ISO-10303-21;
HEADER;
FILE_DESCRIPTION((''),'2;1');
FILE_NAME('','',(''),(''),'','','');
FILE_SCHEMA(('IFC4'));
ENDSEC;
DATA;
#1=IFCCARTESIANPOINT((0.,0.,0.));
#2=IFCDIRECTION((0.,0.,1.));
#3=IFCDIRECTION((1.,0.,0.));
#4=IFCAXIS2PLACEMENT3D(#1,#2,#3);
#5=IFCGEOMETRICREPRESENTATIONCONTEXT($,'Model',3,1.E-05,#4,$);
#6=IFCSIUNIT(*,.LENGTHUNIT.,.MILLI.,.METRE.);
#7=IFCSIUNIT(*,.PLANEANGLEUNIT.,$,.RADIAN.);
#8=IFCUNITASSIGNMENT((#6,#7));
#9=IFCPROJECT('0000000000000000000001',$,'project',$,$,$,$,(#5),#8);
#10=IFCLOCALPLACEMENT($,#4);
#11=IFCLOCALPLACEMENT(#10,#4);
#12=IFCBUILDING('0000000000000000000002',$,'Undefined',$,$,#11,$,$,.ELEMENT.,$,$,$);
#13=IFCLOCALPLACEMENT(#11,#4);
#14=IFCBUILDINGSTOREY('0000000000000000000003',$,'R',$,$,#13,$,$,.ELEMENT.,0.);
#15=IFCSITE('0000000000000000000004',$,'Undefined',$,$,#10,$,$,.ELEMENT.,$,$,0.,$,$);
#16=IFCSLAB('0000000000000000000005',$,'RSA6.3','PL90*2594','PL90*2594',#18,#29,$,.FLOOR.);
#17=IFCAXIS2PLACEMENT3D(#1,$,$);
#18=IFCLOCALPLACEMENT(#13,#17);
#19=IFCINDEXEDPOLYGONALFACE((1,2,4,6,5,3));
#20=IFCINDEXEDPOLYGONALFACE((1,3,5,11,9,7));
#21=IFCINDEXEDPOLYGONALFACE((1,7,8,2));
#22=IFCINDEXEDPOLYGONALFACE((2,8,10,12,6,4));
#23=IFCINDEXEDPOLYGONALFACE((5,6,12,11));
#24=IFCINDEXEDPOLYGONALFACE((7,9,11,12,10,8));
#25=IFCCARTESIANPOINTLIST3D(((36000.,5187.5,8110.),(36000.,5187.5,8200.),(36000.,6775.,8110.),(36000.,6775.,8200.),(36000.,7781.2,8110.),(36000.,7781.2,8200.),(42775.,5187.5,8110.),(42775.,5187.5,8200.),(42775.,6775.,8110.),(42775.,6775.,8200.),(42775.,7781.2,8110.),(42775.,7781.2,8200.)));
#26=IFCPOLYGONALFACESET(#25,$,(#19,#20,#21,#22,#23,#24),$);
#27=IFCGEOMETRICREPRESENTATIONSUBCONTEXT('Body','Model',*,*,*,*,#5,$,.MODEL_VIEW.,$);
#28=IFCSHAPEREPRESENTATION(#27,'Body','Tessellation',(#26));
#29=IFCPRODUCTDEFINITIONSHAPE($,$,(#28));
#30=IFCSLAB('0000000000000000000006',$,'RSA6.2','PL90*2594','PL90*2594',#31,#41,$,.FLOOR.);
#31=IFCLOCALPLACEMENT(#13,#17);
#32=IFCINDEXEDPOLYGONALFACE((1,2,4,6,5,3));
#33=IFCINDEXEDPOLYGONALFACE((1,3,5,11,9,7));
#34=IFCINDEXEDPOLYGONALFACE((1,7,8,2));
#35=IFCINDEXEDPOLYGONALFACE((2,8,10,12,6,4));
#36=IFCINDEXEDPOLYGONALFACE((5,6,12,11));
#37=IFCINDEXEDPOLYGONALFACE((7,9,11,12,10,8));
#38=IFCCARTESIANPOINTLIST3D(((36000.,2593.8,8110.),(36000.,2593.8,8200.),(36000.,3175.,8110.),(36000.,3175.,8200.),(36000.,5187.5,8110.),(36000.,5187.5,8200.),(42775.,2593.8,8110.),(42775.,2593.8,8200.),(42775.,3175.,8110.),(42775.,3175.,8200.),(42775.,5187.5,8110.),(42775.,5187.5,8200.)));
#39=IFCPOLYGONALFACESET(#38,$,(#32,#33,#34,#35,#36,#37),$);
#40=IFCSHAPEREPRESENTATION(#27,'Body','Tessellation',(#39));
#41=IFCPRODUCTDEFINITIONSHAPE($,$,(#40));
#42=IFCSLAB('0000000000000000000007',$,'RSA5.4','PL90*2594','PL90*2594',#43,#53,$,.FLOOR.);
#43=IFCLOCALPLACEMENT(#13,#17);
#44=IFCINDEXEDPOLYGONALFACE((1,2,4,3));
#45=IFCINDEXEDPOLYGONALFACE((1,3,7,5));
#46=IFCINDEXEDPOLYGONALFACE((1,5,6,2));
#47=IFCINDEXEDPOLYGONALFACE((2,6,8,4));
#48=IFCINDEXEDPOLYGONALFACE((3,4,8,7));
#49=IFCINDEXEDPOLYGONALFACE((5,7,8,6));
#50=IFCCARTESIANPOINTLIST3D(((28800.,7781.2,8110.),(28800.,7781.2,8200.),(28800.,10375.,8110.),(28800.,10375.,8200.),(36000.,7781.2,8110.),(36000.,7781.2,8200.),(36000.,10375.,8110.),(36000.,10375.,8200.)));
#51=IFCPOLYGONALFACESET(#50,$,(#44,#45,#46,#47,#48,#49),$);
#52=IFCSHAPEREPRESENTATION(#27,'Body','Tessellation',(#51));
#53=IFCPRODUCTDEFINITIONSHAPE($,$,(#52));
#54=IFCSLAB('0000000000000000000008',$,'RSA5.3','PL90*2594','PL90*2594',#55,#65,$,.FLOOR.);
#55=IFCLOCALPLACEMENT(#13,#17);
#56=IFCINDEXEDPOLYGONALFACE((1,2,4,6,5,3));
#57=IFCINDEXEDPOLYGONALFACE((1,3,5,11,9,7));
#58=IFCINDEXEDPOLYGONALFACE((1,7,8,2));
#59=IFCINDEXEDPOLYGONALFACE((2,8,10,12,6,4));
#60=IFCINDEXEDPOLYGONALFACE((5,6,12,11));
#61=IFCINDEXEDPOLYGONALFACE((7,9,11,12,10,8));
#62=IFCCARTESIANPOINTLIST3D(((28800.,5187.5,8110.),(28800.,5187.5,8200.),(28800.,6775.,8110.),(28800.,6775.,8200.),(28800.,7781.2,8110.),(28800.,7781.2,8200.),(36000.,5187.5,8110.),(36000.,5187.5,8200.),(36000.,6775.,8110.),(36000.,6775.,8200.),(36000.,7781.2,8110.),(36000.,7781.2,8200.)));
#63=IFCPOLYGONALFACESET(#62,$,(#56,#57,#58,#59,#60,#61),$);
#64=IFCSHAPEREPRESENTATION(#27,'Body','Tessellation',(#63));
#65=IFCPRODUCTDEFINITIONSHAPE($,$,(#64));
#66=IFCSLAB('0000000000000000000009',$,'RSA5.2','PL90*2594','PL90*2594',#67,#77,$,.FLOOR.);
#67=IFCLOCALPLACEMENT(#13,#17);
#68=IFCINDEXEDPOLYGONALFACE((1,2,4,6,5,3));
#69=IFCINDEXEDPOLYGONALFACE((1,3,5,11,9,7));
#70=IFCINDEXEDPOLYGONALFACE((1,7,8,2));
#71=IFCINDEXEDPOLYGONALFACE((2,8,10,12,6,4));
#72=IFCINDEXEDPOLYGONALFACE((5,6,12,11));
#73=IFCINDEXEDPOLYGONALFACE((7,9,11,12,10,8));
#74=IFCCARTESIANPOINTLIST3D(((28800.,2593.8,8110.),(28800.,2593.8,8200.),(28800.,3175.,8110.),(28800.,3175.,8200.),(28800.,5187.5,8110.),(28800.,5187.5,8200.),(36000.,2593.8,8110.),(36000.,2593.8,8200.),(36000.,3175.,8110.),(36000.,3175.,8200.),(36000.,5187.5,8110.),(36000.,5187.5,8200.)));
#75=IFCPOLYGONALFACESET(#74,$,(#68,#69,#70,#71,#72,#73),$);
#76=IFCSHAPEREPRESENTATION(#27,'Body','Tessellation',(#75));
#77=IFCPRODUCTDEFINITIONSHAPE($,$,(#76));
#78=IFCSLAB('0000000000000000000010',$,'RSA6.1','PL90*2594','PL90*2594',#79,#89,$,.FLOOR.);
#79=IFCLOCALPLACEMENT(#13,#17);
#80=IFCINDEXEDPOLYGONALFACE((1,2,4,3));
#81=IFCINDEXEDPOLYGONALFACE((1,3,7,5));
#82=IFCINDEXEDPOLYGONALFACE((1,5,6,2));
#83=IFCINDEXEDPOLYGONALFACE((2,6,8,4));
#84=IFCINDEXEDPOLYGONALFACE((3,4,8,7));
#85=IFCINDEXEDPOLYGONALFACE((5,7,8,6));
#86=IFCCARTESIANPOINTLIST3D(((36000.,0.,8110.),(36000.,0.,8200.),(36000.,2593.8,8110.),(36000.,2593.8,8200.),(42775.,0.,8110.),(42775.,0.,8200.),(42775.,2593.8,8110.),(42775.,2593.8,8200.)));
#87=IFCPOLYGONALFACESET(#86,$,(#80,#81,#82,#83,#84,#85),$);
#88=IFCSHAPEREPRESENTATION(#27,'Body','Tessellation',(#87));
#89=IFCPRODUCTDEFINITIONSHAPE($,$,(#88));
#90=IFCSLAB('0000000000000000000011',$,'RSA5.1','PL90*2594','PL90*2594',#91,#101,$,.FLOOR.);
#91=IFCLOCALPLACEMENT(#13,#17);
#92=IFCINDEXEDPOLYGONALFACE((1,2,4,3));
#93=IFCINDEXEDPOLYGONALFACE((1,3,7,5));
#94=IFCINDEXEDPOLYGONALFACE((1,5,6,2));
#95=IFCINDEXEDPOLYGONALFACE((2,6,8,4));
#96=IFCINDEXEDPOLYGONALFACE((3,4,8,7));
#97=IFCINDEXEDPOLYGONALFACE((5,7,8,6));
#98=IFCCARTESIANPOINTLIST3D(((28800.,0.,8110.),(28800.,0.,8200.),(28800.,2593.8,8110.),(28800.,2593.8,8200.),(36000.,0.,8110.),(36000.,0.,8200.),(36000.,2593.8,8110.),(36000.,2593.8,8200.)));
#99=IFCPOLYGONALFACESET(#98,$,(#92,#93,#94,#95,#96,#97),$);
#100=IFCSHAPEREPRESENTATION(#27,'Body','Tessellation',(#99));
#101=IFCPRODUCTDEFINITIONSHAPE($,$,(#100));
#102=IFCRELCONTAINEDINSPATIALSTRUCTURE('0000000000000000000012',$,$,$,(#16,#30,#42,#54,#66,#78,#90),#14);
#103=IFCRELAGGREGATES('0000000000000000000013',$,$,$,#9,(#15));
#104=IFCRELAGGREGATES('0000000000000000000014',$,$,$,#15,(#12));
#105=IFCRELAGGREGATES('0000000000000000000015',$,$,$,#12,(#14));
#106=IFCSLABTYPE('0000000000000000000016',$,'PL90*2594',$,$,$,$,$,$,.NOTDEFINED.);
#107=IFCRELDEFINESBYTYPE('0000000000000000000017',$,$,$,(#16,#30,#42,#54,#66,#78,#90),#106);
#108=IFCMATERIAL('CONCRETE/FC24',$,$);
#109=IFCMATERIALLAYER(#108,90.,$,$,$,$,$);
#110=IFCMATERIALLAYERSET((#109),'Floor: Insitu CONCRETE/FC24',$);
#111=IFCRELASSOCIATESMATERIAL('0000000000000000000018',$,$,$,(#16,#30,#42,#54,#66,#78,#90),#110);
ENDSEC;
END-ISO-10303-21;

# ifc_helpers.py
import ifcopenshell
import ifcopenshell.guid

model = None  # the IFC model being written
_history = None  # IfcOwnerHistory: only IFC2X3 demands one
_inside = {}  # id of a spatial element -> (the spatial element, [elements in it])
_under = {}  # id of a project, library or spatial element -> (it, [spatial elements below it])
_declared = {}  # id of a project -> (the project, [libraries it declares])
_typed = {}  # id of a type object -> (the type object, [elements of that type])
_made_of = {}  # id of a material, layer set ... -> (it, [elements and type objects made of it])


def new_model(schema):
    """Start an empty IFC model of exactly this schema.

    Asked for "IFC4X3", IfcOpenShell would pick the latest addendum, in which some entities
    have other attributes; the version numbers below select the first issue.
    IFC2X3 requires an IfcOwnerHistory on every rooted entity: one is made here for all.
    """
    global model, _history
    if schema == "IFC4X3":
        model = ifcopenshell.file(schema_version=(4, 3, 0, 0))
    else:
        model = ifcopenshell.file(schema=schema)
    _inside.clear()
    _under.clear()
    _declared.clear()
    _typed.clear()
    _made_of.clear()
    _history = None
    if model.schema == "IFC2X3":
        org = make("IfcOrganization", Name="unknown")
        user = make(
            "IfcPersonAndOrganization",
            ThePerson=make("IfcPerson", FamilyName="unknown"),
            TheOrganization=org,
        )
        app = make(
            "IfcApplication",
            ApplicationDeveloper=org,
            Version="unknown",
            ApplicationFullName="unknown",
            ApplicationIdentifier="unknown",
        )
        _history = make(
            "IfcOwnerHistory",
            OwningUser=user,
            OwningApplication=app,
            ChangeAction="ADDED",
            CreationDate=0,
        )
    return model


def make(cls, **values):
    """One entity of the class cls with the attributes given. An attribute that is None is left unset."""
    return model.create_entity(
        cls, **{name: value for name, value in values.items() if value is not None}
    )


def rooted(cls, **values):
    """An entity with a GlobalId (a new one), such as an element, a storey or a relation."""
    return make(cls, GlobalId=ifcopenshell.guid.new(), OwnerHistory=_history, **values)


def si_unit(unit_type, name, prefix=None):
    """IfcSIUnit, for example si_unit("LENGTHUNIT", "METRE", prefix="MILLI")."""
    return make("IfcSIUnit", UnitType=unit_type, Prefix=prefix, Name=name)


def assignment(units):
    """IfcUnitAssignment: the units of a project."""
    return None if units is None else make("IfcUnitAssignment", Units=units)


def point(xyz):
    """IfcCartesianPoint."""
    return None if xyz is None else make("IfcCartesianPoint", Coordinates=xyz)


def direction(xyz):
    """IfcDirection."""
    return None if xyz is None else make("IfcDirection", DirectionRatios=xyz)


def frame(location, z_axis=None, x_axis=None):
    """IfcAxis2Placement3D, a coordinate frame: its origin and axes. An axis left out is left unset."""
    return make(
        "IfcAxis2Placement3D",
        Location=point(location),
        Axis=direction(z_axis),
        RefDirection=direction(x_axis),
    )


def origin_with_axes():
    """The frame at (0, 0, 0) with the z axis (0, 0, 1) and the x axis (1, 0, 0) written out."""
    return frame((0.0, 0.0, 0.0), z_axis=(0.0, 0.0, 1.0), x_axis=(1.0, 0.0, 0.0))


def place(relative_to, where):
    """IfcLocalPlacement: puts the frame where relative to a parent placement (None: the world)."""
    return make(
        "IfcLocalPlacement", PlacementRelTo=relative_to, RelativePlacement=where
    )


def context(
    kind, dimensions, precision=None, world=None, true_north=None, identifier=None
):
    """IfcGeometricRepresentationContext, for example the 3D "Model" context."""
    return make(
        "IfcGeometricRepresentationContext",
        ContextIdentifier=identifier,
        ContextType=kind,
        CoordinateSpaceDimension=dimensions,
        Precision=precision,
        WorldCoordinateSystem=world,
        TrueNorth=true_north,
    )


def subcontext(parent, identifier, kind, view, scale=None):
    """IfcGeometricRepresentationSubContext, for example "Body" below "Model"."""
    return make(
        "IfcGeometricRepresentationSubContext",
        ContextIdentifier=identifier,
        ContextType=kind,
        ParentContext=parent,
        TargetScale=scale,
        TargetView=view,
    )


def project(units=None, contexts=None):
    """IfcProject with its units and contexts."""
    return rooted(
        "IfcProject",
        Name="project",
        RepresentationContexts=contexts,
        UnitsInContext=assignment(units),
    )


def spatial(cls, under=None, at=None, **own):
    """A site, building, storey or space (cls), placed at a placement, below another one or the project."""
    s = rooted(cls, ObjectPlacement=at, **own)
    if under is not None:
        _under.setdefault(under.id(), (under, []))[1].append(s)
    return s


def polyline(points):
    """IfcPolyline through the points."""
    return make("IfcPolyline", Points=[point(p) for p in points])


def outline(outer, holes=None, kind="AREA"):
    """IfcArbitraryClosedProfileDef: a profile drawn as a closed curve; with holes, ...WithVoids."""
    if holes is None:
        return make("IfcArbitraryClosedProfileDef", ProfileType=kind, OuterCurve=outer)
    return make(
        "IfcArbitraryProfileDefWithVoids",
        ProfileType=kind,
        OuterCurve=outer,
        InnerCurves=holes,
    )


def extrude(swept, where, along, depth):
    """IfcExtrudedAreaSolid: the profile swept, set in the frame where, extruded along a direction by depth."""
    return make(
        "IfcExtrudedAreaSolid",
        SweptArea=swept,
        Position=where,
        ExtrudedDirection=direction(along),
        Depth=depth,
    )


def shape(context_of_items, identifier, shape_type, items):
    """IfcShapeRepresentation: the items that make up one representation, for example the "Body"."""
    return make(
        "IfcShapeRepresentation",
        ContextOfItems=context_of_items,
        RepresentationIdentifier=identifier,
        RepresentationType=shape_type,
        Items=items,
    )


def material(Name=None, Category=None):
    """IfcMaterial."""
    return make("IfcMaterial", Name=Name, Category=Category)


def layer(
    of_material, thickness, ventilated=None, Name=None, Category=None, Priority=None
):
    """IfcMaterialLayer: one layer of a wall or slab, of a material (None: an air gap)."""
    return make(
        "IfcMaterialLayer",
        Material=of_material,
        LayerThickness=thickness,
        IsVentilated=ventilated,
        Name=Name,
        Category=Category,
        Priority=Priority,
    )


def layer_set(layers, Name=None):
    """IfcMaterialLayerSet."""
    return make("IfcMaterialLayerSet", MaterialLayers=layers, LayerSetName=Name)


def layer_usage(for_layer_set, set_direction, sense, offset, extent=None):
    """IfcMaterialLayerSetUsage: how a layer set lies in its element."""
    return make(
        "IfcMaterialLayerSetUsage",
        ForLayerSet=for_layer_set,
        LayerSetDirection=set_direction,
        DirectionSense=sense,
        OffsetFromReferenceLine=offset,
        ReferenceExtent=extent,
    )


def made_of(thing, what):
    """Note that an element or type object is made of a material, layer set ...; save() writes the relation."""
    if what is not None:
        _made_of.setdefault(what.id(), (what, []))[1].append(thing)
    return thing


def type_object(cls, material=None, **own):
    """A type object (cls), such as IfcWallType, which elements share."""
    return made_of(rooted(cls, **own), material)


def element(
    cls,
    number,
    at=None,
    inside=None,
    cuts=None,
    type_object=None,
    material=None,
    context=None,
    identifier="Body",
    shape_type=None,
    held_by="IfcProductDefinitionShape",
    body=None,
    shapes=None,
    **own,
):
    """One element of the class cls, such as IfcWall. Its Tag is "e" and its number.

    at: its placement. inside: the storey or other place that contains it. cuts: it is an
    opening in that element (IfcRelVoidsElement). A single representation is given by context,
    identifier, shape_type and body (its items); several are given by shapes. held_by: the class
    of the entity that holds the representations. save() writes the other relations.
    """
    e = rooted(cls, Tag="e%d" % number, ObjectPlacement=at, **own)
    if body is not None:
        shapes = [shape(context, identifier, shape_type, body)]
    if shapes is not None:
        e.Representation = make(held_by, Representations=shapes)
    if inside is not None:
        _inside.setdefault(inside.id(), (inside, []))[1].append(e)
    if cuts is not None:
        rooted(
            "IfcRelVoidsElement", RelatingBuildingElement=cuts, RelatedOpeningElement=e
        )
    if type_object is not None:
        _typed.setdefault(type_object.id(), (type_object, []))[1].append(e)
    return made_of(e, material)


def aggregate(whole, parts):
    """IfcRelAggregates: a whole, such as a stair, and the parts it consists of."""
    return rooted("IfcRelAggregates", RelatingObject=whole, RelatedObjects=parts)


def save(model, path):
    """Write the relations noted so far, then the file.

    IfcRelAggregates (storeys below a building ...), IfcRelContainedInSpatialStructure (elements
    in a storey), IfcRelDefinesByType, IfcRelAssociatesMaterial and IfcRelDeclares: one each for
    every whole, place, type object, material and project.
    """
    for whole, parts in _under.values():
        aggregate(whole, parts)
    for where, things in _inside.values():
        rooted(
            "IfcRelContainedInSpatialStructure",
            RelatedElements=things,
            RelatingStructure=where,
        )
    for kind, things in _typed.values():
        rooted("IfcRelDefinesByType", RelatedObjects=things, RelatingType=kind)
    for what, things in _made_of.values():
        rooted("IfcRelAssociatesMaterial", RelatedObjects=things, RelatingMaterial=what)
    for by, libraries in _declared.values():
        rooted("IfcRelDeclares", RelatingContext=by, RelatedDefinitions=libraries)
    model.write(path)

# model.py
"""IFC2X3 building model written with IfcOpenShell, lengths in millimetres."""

from ifc_helpers import new_model, si_unit, frame, origin_with_axes, place, context, subcontext, project, spatial, polyline, outline, extrude, material, layer, layer_set, layer_usage, type_object, element, save


model = new_model("IFC2X3")

# Units and contexts
model_context = context("Model", 3, precision=1e-05, world=origin_with_axes())
body_context = subcontext(model_context, "Body", "Model", "MODEL_VIEW")
ifc_project = project(units=[si_unit("LENGTHUNIT", "METRE", prefix="MILLI"), si_unit("PLANEANGLEUNIT", "RADIAN")], contexts=[model_context])

# Site, building, storey
site_placement = place(None, origin_with_axes())
site = spatial("IfcSite", under=ifc_project, at=site_placement, Name="Undefined", CompositionType="ELEMENT", RefElevation=0.0)
building_placement = place(site_placement, origin_with_axes())
building = spatial("IfcBuilding", under=site, at=building_placement, Name="Undefined", CompositionType="ELEMENT")
storey_placement = place(building_placement, origin_with_axes())
storey = spatial("IfcBuildingStorey", under=building, at=storey_placement, Name="R", CompositionType="ELEMENT", Elevation=0.0)

# Slabs
ifc_material_1 = material(Name="CONCRETE/FC24")
ifc_layer = layer(ifc_material_1, 90.0)
ifc_layer_set = layer_set([ifc_layer], Name="Floor: Insitu CONCRETE/FC24")
slab_type_1 = type_object("IfcSlabType", Name="PL90*2594", PredefinedType="NOTDEFINED")
ifc_layer_usage_1 = layer_usage(ifc_layer_set, "AXIS3", "POSITIVE", -45.0)
slab_1_placement = place(storey_placement, frame((36000.0, 5187.5, 8155.0), z_axis=(0.0, 0.0, 1.0), x_axis=(1.0, 0.0, 0.0)))
element("IfcSlab", 1, at=slab_1_placement, inside=storey, type_object=slab_type_1, material=ifc_layer_usage_1, Name="RSA6.3", Description="PL90*2594", ObjectType="PL90*2594", PredefinedType="FLOOR", context=body_context, shape_type="SweptSolid", body=[
    extrude(outline(polyline([(0.0, 0.0), (6775.0, 0.0), (6775.0, 1587.5), (6775.0, 2593.8), (0.0, 2593.8), (0.0, 1587.5), (0.0, 0.0)])), frame((0.0, 0.0, -45.0), z_axis=(0.0, 0.0, 1.0), x_axis=(1.0, 0.0, 0.0)), (0.0, 0.0, 1.0), 90.0),
])
ifc_layer_usage_2 = layer_usage(ifc_layer_set, "AXIS3", "POSITIVE", -45.0)
slab_2_placement = place(storey_placement, frame((36000.0, 2593.8, 8155.0), z_axis=(0.0, 0.0, 1.0), x_axis=(1.0, 0.0, 0.0)))
element("IfcSlab", 2, at=slab_2_placement, inside=storey, type_object=slab_type_1, material=ifc_layer_usage_2, Name="RSA6.2", Description="PL90*2594", ObjectType="PL90*2594", PredefinedType="FLOOR", context=body_context, shape_type="SweptSolid", body=[
    extrude(outline(polyline([(0.0, 0.0), (6775.0, 0.0), (6775.0, 581.2), (6775.0, 2593.8), (0.0, 2593.8), (0.0, 581.2), (0.0, 0.0)])), frame((0.0, 0.0, -45.0), z_axis=(0.0, 0.0, 1.0), x_axis=(1.0, 0.0, 0.0)), (0.0, 0.0, 1.0), 90.0),
])
ifc_layer_usage_3 = layer_usage(ifc_layer_set, "AXIS3", "POSITIVE", -45.0)
slab_3_placement = place(storey_placement, frame((28800.0, 7781.2, 8155.0), z_axis=(0.0, 0.0, 1.0), x_axis=(1.0, 0.0, 0.0)))
element("IfcSlab", 3, at=slab_3_placement, inside=storey, type_object=slab_type_1, material=ifc_layer_usage_3, Name="RSA5.4", Description="PL90*2594", ObjectType="PL90*2594", PredefinedType="FLOOR", context=body_context, shape_type="SweptSolid", body=[
    extrude(outline(polyline([(0.0, 0.0), (7200.0, 0.0), (7200.0, 2593.8), (0.0, 2593.8), (0.0, 0.0)])), frame((0.0, 0.0, -45.0), z_axis=(0.0, 0.0, 1.0), x_axis=(1.0, 0.0, 0.0)), (0.0, 0.0, 1.0), 90.0),
])
ifc_layer_usage_4 = layer_usage(ifc_layer_set, "AXIS3", "POSITIVE", -45.0)
slab_4_placement = place(storey_placement, frame((28800.0, 5187.5, 8155.0), z_axis=(0.0, 0.0, 1.0), x_axis=(1.0, 0.0, 0.0)))
element("IfcSlab", 4, at=slab_4_placement, inside=storey, type_object=slab_type_1, material=ifc_layer_usage_4, Name="RSA5.3", Description="PL90*2594", ObjectType="PL90*2594", PredefinedType="FLOOR", context=body_context, shape_type="SweptSolid", body=[
    extrude(outline(polyline([(0.0, 0.0), (7200.0, 0.0), (7200.0, 1587.5), (7200.0, 2593.8), (0.0, 2593.8), (0.0, 1587.5), (0.0, 0.0)])), frame((0.0, 0.0, -45.0), z_axis=(0.0, 0.0, 1.0), x_axis=(1.0, 0.0, 0.0)), (0.0, 0.0, 1.0), 90.0),
])
ifc_layer_usage_5 = layer_usage(ifc_layer_set, "AXIS3", "POSITIVE", -45.0)
slab_5_placement = place(storey_placement, frame((28800.0, 2593.8, 8155.0), z_axis=(0.0, 0.0, 1.0), x_axis=(1.0, 0.0, 0.0)))
element("IfcSlab", 5, at=slab_5_placement, inside=storey, type_object=slab_type_1, material=ifc_layer_usage_5, Name="RSA5.2", Description="PL90*2594", ObjectType="PL90*2594", PredefinedType="FLOOR", context=body_context, shape_type="SweptSolid", body=[
    extrude(outline(polyline([(0.0, 0.0), (7200.0, 0.0), (7200.0, 581.2), (7200.0, 2593.8), (0.0, 2593.8), (0.0, 581.2), (0.0, 0.0)])), frame((0.0, 0.0, -45.0), z_axis=(0.0, 0.0, 1.0), x_axis=(1.0, 0.0, 0.0)), (0.0, 0.0, 1.0), 90.0),
])
ifc_layer_usage_6 = layer_usage(ifc_layer_set, "AXIS3", "POSITIVE", -45.0)
slab_6_placement = place(storey_placement, frame((36000.0, 0.0, 8155.0), z_axis=(0.0, 0.0, 1.0), x_axis=(1.0, 0.0, 0.0)))
element("IfcSlab", 6, at=slab_6_placement, inside=storey, type_object=slab_type_1, material=ifc_layer_usage_6, Name="RSA6.1", Description="PL90*2594", ObjectType="PL90*2594", PredefinedType="FLOOR", context=body_context, shape_type="SweptSolid", body=[
    extrude(outline(polyline([(0.0, 0.0), (6775.0, 0.0), (6775.0, 2593.8), (0.0, 2593.8), (0.0, 0.0)])), frame((0.0, 0.0, -45.0), z_axis=(0.0, 0.0, 1.0), x_axis=(1.0, 0.0, 0.0)), (0.0, 0.0, 1.0), 90.0),
])
ifc_layer_usage_7 = layer_usage(ifc_layer_set, "AXIS3", "POSITIVE", -45.0)
slab_7_placement = place(storey_placement, frame((28800.0, 0.0, 8155.0), z_axis=(0.0, 0.0, 1.0), x_axis=(1.0, 0.0, 0.0)))
element("IfcSlab", 7, at=slab_7_placement, inside=storey, type_object=slab_type_1, material=ifc_layer_usage_7, Name="RSA5.1", Description="PL90*2594", ObjectType="PL90*2594", PredefinedType="FLOOR", context=body_context, shape_type="SweptSolid", body=[
    extrude(outline(polyline([(0.0, 0.0), (7200.0, 0.0), (7200.0, 2593.8), (0.0, 2593.8), (0.0, 0.0)])), frame((0.0, 0.0, -45.0), z_axis=(0.0, 0.0, 1.0), x_axis=(1.0, 0.0, 0.0)), (0.0, 0.0, 1.0), 90.0),
])

save(model, "model.ifc")
